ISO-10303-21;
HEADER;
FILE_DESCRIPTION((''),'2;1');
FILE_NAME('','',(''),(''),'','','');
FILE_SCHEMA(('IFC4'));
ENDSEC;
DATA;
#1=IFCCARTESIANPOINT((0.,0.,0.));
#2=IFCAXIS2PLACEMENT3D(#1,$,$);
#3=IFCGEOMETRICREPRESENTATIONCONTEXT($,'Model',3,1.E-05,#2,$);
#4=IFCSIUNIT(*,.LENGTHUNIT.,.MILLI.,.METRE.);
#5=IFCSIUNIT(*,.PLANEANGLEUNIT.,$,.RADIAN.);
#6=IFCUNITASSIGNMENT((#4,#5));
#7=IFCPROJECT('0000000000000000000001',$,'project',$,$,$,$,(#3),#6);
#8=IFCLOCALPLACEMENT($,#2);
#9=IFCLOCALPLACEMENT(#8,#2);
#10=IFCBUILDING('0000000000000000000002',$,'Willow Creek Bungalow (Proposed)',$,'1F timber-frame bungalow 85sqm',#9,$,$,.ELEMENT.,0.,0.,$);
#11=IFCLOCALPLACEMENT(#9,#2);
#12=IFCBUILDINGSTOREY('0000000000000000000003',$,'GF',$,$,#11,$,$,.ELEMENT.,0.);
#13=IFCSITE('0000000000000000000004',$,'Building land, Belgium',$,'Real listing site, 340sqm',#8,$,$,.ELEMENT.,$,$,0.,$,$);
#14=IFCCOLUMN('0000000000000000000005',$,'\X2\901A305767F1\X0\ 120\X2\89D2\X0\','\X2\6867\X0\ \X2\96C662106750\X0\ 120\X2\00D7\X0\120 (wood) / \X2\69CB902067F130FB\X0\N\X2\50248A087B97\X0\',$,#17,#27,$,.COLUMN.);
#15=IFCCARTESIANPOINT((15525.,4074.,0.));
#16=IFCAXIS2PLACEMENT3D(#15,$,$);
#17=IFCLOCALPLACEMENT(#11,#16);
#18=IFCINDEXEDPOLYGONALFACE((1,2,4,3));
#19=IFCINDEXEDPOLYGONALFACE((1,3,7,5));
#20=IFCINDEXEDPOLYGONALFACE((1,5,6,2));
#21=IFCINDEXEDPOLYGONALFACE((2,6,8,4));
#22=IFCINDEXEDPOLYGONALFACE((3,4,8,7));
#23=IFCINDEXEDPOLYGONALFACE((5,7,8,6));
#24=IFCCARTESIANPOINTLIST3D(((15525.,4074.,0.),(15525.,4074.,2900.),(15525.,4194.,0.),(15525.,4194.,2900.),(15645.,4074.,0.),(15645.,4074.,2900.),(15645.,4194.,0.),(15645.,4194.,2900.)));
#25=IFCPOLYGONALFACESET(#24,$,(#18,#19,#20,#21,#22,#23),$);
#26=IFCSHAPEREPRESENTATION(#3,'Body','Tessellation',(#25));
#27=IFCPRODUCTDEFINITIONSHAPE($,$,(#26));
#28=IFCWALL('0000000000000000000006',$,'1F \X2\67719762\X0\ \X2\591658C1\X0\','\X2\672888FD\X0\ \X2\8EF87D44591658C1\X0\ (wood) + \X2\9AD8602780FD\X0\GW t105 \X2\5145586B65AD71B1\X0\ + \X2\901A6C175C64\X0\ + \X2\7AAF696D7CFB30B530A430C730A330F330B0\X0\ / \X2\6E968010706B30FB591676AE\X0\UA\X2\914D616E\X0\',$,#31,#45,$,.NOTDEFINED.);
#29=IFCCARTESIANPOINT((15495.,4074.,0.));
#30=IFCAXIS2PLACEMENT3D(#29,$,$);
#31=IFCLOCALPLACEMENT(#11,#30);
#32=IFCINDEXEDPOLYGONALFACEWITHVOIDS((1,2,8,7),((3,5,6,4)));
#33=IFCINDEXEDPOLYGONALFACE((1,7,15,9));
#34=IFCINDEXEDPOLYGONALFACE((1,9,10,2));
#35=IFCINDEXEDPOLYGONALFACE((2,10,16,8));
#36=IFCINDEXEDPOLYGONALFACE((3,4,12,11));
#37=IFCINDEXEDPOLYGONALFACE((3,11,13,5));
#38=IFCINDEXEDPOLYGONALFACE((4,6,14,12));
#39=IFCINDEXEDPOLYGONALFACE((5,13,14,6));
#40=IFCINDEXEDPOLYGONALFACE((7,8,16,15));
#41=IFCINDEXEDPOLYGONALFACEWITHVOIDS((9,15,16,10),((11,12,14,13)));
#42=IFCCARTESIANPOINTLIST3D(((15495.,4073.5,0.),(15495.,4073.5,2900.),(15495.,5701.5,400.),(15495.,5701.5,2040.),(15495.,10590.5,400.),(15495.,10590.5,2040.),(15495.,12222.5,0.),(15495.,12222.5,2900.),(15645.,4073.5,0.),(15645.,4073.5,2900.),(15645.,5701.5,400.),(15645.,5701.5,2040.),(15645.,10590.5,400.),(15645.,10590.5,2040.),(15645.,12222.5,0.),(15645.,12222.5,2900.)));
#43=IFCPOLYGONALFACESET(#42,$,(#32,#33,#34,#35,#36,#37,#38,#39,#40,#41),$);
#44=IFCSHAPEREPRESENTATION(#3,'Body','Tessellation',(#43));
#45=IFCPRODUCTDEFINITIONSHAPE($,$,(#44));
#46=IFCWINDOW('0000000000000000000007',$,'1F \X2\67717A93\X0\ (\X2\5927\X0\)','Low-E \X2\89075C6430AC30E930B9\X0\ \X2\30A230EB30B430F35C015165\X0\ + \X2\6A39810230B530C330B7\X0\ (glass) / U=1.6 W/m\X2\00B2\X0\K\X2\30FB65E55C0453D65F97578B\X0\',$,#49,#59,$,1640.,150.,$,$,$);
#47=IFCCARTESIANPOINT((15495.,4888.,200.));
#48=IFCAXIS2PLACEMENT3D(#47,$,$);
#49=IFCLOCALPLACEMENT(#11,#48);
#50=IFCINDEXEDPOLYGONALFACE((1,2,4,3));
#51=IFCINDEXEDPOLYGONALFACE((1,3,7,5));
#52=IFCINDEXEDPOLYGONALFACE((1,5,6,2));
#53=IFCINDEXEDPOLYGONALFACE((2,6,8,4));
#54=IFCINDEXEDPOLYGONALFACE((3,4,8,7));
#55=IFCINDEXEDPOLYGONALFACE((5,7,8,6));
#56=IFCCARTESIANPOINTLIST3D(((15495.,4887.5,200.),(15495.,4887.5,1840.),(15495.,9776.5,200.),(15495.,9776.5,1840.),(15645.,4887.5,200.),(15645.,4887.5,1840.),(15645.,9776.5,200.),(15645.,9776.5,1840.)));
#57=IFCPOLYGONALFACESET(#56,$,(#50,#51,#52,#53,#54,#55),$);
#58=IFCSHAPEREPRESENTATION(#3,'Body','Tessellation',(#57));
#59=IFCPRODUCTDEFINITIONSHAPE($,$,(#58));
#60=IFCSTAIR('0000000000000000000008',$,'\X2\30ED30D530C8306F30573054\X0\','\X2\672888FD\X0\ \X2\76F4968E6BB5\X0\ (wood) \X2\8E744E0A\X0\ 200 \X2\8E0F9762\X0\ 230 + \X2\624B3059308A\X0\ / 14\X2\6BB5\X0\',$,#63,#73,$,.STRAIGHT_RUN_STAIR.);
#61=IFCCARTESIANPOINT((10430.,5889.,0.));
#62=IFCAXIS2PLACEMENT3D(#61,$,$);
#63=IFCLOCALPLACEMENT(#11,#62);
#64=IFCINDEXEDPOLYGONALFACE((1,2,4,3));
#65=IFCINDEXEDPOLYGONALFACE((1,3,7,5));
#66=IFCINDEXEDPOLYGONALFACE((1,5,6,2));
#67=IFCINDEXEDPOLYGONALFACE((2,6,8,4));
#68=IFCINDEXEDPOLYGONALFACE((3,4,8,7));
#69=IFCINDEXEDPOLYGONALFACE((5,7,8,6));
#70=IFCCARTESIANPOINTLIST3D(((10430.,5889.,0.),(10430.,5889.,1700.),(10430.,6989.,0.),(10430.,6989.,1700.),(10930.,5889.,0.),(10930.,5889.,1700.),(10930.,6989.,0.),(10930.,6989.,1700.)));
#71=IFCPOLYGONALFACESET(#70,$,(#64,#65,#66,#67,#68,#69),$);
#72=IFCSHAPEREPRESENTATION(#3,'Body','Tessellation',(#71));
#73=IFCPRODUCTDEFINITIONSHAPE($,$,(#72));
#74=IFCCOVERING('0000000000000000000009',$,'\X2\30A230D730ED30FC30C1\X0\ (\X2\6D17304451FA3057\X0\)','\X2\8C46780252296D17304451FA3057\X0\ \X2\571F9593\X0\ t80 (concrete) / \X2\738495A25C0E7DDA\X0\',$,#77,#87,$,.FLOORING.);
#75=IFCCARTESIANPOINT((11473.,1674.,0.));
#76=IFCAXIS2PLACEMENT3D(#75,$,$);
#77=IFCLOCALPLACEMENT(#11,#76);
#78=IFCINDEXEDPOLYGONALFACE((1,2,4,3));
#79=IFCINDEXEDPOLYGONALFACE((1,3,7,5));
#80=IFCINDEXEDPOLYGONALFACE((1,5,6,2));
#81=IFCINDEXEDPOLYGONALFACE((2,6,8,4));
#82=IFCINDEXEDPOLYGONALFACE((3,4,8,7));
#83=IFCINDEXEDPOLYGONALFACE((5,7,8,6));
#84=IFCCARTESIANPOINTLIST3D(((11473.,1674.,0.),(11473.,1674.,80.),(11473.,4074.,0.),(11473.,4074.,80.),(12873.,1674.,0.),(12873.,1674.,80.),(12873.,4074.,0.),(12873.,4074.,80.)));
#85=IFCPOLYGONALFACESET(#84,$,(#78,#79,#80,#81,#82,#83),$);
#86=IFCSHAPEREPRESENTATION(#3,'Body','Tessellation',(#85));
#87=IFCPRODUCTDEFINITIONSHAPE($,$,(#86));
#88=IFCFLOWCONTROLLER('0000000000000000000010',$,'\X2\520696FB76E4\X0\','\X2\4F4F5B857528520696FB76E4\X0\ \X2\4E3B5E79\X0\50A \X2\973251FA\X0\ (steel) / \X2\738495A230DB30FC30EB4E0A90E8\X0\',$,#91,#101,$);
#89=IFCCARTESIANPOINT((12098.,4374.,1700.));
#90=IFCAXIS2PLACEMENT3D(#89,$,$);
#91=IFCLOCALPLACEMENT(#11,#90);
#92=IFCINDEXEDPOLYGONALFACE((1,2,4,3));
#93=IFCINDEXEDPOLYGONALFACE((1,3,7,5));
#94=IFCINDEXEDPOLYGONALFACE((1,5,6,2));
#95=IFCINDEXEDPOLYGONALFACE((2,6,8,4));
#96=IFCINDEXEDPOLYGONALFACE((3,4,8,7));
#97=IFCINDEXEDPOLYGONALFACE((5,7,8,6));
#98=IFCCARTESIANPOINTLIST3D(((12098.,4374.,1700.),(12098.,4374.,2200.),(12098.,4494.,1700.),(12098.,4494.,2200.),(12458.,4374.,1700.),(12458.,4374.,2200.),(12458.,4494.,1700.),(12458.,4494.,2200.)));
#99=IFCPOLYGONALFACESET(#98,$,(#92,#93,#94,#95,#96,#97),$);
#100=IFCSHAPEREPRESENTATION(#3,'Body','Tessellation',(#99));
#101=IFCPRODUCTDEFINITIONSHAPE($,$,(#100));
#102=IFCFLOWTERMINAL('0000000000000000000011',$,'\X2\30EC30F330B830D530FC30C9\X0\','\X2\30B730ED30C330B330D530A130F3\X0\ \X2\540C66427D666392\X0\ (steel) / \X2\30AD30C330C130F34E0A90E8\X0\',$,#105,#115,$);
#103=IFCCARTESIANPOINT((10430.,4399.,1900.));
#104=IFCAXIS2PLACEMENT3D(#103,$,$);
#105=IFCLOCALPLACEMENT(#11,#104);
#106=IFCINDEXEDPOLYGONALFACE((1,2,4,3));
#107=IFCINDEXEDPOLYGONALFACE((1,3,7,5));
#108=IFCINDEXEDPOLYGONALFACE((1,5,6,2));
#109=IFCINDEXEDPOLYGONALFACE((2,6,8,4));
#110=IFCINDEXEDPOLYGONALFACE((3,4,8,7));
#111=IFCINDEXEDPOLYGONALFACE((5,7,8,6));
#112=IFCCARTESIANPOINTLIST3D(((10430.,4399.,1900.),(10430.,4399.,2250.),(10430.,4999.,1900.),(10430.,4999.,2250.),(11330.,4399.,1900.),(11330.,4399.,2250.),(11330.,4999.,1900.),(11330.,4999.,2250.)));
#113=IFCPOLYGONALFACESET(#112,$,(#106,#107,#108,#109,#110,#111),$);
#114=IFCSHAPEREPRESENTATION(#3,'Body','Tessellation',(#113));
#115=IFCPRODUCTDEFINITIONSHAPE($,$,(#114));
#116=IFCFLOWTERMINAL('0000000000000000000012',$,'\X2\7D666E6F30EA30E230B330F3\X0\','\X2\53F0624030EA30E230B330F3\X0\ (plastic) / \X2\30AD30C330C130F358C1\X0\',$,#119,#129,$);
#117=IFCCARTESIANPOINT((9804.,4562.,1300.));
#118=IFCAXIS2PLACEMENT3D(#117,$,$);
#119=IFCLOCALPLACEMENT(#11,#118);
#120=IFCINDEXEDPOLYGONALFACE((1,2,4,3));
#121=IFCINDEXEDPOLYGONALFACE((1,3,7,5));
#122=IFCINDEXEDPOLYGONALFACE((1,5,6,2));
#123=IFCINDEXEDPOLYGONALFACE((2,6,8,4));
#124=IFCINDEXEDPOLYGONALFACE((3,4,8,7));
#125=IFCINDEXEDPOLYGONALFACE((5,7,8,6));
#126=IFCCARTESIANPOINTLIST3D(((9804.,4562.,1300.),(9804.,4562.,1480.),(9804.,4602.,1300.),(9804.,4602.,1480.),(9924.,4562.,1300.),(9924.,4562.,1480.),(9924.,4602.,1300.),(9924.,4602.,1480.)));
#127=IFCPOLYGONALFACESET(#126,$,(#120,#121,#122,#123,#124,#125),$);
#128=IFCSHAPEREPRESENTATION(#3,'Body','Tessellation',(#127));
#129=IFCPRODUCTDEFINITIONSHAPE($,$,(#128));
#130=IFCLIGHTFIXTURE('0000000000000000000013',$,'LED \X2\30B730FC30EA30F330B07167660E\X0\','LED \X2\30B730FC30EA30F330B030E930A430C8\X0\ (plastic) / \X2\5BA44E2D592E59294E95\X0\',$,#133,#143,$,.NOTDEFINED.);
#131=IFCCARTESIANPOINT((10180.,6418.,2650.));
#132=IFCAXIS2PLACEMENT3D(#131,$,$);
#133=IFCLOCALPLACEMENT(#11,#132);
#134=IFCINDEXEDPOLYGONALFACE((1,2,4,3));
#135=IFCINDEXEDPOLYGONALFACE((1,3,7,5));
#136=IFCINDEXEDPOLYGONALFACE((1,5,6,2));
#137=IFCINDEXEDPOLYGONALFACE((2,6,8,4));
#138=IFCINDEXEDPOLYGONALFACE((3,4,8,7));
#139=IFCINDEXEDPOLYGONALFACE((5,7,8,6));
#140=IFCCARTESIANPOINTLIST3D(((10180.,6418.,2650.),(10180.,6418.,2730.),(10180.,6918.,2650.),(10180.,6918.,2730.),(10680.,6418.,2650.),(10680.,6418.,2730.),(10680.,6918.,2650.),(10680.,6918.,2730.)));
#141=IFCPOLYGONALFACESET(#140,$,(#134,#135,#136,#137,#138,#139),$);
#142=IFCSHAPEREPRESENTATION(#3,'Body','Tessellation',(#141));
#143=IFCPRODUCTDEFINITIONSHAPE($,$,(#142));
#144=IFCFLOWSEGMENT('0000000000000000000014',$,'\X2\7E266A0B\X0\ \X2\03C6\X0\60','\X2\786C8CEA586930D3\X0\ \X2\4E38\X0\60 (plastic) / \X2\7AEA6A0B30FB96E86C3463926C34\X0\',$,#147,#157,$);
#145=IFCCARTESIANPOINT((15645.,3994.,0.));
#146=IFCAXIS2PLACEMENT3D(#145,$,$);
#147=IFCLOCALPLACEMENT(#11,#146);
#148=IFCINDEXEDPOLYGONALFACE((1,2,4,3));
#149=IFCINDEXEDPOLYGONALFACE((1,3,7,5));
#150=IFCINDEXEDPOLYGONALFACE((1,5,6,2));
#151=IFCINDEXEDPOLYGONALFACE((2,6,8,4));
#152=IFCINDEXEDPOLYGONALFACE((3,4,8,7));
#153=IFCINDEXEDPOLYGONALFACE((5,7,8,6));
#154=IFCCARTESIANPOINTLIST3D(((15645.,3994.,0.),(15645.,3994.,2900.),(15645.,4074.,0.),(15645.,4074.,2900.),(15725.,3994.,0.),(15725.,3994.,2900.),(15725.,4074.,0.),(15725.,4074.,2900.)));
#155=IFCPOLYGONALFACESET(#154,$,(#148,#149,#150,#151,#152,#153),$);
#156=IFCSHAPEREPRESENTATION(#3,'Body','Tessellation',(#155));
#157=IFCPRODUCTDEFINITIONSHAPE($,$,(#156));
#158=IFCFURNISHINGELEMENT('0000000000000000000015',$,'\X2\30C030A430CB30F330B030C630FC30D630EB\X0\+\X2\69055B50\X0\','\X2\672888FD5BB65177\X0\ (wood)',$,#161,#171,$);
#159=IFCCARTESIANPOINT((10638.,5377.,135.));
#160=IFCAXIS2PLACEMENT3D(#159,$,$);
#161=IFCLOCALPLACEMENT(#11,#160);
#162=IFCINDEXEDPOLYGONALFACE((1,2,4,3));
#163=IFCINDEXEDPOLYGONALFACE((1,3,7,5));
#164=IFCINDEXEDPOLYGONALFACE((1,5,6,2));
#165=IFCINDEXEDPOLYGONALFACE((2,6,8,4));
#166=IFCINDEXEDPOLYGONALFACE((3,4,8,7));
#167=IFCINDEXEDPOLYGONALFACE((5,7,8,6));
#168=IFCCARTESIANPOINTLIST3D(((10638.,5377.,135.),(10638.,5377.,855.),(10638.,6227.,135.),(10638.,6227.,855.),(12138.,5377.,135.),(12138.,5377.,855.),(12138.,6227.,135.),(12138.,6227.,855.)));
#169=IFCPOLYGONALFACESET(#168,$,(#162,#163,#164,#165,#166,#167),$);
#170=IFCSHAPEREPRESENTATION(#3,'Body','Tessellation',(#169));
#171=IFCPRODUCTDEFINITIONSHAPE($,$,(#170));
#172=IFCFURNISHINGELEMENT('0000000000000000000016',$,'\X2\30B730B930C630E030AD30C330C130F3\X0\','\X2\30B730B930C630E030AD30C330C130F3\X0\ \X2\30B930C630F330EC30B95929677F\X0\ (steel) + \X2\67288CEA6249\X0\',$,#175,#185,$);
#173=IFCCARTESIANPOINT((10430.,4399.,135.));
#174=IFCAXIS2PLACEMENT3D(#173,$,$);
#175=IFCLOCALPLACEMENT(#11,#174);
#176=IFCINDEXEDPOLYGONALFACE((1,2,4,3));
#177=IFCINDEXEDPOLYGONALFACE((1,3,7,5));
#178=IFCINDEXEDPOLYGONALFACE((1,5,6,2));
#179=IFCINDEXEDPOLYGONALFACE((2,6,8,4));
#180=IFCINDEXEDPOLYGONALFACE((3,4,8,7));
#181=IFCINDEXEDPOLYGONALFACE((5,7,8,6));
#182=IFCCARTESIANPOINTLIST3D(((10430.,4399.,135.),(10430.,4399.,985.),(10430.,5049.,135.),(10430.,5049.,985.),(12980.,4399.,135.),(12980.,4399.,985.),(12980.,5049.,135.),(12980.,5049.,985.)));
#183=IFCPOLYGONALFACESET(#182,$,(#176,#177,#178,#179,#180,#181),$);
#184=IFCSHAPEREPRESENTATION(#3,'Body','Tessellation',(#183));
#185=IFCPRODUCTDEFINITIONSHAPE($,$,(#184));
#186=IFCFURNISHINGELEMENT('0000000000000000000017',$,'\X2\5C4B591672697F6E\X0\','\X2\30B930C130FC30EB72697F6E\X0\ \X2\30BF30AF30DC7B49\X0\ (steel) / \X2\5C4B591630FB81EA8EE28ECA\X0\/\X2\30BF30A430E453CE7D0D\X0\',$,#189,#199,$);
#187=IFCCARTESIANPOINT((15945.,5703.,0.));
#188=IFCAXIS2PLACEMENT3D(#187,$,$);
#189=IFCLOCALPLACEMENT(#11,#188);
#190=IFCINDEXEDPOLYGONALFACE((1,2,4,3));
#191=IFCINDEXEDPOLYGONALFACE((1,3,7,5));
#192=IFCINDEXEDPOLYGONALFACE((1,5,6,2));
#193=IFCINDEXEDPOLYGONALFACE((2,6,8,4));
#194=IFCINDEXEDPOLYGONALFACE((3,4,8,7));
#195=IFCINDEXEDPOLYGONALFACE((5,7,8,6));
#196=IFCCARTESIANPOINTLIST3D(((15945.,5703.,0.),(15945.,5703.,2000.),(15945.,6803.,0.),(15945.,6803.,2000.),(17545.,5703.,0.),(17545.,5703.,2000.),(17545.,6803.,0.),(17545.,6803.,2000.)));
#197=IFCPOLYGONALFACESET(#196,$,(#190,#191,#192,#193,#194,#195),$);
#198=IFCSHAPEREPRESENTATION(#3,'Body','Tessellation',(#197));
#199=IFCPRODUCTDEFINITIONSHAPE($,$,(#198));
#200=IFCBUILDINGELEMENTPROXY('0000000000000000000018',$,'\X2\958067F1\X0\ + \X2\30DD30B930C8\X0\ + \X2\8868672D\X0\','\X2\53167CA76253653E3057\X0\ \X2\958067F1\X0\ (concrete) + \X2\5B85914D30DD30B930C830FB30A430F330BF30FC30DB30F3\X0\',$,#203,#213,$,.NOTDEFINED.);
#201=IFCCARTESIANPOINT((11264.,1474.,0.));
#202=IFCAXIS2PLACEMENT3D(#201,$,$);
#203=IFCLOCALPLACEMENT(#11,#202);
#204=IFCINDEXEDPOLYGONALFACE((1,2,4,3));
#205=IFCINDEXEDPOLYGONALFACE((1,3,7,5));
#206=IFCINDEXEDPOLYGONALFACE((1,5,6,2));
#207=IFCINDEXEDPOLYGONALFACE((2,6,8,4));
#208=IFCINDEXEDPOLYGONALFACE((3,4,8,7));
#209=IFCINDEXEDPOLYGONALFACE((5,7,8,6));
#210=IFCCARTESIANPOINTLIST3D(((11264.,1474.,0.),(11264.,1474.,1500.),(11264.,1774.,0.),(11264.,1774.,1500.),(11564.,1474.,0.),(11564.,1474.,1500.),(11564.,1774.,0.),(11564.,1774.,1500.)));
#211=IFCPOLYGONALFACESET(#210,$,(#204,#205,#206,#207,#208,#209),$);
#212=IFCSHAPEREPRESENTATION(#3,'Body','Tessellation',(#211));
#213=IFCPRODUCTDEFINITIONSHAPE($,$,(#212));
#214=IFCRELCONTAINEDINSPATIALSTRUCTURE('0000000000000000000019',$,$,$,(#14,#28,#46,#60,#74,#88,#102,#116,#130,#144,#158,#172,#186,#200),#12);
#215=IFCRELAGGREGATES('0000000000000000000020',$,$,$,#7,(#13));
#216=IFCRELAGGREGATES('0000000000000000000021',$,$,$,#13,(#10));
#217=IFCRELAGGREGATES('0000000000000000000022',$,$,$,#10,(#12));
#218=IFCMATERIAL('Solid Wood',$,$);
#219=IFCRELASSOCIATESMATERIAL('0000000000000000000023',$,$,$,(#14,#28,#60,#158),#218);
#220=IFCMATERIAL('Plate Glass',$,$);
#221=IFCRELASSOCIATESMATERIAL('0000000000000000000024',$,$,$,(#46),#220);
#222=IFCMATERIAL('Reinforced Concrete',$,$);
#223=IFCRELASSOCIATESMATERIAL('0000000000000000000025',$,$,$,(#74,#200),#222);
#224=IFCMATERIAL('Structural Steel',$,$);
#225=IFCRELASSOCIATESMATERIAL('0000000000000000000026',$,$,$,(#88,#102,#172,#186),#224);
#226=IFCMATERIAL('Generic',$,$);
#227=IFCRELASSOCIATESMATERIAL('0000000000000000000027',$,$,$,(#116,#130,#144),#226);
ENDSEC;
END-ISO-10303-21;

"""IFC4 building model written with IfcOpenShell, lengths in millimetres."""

from ifc_helpers import new_model, si_unit, frame, frame_2d, origin, place, context, project, spatial, rectangle, extrude, material, element, fill, save


model = new_model("IFC4")

# Units and contexts
model_context = context("Model", 3, precision=1e-05, world=origin())
ifc_project = project(units=[si_unit("LENGTHUNIT", "METRE", prefix="MILLI"), si_unit("PLANEANGLEUNIT", "RADIAN")], contexts=[model_context])

# Site, building, storey
site_placement = place(None, origin())
site = spatial("IfcSite", under=ifc_project, at=site_placement, Name="Building land, Belgium", ObjectType="Real listing site, 340sqm", CompositionType="ELEMENT", RefElevation=0.0)
building_placement = place(site_placement, origin())
building = spatial("IfcBuilding", under=site, at=building_placement, Name="Willow Creek Bungalow (Proposed)", ObjectType="1F timber-frame bungalow 85sqm", CompositionType="ELEMENT", ElevationOfRefHeight=0.0, ElevationOfTerrain=0.0)
storey_placement = place(building_placement, origin())
storey = spatial("IfcBuildingStorey", under=building, at=storey_placement, Name="GF", CompositionType="ELEMENT", Elevation=0.0)

# Column
ifc_material_1 = material(Name="Solid Wood")
column_1_placement = place(storey_placement, frame((15525.0, 4074.0, 0.0)))
element("IfcColumn", 1, at=column_1_placement, inside=storey, material=ifc_material_1, Name="通し柱 120角", Description="桧 集成材 120×120 (wood) / 構造柱・N値計算", PredefinedType="COLUMN", context=model_context, shape_type="SweptSolid", body=[
    extrude(rectangle(XDim=120.0, YDim=120.0, at=frame_2d((60.0, 60.0))), frame((15525.0, 4074.0, 0.0)), (0.0, 0.0, 1.0), 2900.0),
])

# Wall, opening, window
wall_1_placement = place(storey_placement, frame((15495.0, 4074.0, 0.0)))
wall_1 = element("IfcWall", 2, at=wall_1_placement, inside=storey, material=ifc_material_1, Name="1F 東面 外壁", Description="木製 軸組外壁 (wood) + 高性能GW t105 充填断熱 + 通気層 + 窯業系サイディング / 準耐火・外皮UA配慮", PredefinedType="NOTDEFINED", context=model_context, shape_type="SweptSolid", body=[
    extrude(rectangle(XDim=150.0, YDim=8149.0, at=frame_2d((75.0, 4074.0))), frame((15495.0, 4074.0, 0.0)), (0.0, 0.0, 1.0), 2900.0),
])
opening_placement = place(storey_placement, frame((15495.0, 4888.0, 200.0)))
opening = element("IfcOpeningElement", 3, at=opening_placement, cuts=wall_1, PredefinedType="NOTDEFINED", context=model_context, shape_type="SweptSolid", body=[
    extrude(rectangle(XDim=150.0, YDim=4889.0, at=frame_2d((75.0, 2444.0))), frame((15495.0, 4888.0, 200.0)), (0.0, 0.0, 1.0), 1640.0),
])
ifc_material_2 = material(Name="Plate Glass")
window_placement = place(storey_placement, frame((15495.0, 4888.0, 200.0)))
window = element("IfcWindow", 4, at=window_placement, inside=storey, material=ifc_material_2, Name="1F 東窓 (大)", Description="Low-E 複層ガラス アルゴン封入 + 樹脂サッシ (glass) / U=1.6 W/m²K・日射取得型", OverallHeight=1640.0, OverallWidth=150.0, context=model_context, shape_type="SweptSolid", body=[
    extrude(rectangle(XDim=150.0, YDim=4889.0, at=frame_2d((75.0, 2444.0))), frame((15495.0, 4888.0, 200.0)), (0.0, 0.0, 1.0), 1640.0),
])
fill(opening, window)

# Stair
stair_placement = place(storey_placement, frame((10430.0, 5889.0, 0.0)))
element("IfcStair", 5, at=stair_placement, inside=storey, material=ifc_material_1, Name="ロフトはしご", Description="木製 直階段 (wood) 蹴上 200 踏面 230 + 手すり / 14段", PredefinedType="STRAIGHT_RUN_STAIR", context=model_context, shape_type="SweptSolid", body=[
    extrude(rectangle(XDim=500.0, YDim=1100.0, at=frame_2d((250.0, 550.0))), frame((10430.0, 5889.0, 0.0)), (0.0, 0.0, 1.0), 1700.0),
])

# Covering
ifc_material_3 = material(Name="Reinforced Concrete")
covering_placement = place(storey_placement, frame((11473.0, 1674.0, 0.0)))
element("IfcCovering", 6, at=covering_placement, inside=storey, material=ifc_material_3, Name="アプローチ (洗い出し)", Description="豆砂利洗い出し 土間 t80 (concrete) / 玄関導線", PredefinedType="FLOORING", context=model_context, shape_type="SweptSolid", body=[
    extrude(rectangle(XDim=1400.0, YDim=2400.0, at=frame_2d((700.0, 1200.0))), frame((11473.0, 1674.0, 0.0)), (0.0, 0.0, 1.0), 80.0),
])

# Flow controller
ifc_material_4 = material(Name="Structural Steel")
flow_controller_placement = place(storey_placement, frame((12098.0, 4374.0, 1700.0)))
element("IfcFlowController", 7, at=flow_controller_placement, inside=storey, material=ifc_material_4, Name="分電盤", Description="住宅用分電盤 主幹50A 露出 (steel) / 玄関ホール上部", context=model_context, shape_type="SweptSolid", body=[
    extrude(rectangle(XDim=360.0, YDim=120.0, at=frame_2d((180.0, 60.0))), frame((12098.0, 4374.0, 1700.0)), (0.0, 0.0, 1.0), 500.0),
])

# Flow terminals
flow_terminal_1_placement = place(storey_placement, frame((10430.0, 4399.0, 1900.0)))
element("IfcFlowTerminal", 8, at=flow_terminal_1_placement, inside=storey, material=ifc_material_4, Name="レンジフード", Description="シロッコファン 同時給排 (steel) / キッチン上部", context=model_context, shape_type="SweptSolid", body=[
    extrude(rectangle(XDim=900.0, YDim=600.0, at=frame_2d((450.0, 300.0))), frame((10430.0, 4399.0, 1900.0)), (0.0, 0.0, 1.0), 350.0),
])
ifc_material_5 = material(Name="Generic")
flow_terminal_2_placement = place(storey_placement, frame((9804.0, 4562.0, 1300.0)))
element("IfcFlowTerminal", 9, at=flow_terminal_2_placement, inside=storey, material=ifc_material_5, Name="給湯リモコン", Description="台所リモコン (plastic) / キッチン壁", context=model_context, shape_type="SweptSolid", body=[
    extrude(rectangle(XDim=120.0, YDim=40.0, at=frame_2d((60.0, 20.0))), frame((9804.0, 4562.0, 1300.0)), (0.0, 0.0, 1.0), 180.0),
])

# Light fixture
light_fixture_placement = place(storey_placement, frame((10180.0, 6418.0, 2650.0)))
element("IfcLightFixture", 10, at=light_fixture_placement, inside=storey, material=ifc_material_5, Name="LED シーリング照明", Description="LED シーリングライト (plastic) / 室中央天井", PredefinedType="NOTDEFINED", context=model_context, shape_type="SweptSolid", body=[
    extrude(rectangle(XDim=500.0, YDim=500.0, at=frame_2d((250.0, 250.0))), frame((10180.0, 6418.0, 2650.0)), (0.0, 0.0, 1.0), 80.0),
])

# Flow segment
flow_segment_placement = place(storey_placement, frame((15645.0, 3994.0, 0.0)))
element("IfcFlowSegment", 11, at=flow_segment_placement, inside=storey, material=ifc_material_5, Name="縦樋 φ60", Description="硬質塩ビ 丸60 (plastic) / 竪樋・雨水排水", context=model_context, shape_type="SweptSolid", body=[
    extrude(rectangle(XDim=80.0, YDim=80.0, at=frame_2d((40.0, 40.0))), frame((15645.0, 3994.0, 0.0)), (0.0, 0.0, 1.0), 2900.0),
])

# Furnishing elements
furnishing_1_placement = place(storey_placement, frame((10638.0, 5377.0, 135.0)))
element("IfcFurnishingElement", 12, at=furnishing_1_placement, inside=storey, material=ifc_material_1, Name="ダイニングテーブル+椅子", Description="木製家具 (wood)", context=model_context, shape_type="SweptSolid", body=[
    extrude(rectangle(XDim=1500.0, YDim=850.0, at=frame_2d((750.0, 425.0))), frame((10638.0, 5377.0, 135.0)), (0.0, 0.0, 1.0), 720.0),
])
furnishing_2_placement = place(storey_placement, frame((10430.0, 4399.0, 135.0)))
element("IfcFurnishingElement", 13, at=furnishing_2_placement, inside=storey, material=ifc_material_4, Name="システムキッチン", Description="システムキッチン ステンレス天板 (steel) + 木質扉", context=model_context, shape_type="SweptSolid", body=[
    extrude(rectangle(XDim=2550.0, YDim=650.0, at=frame_2d((1275.0, 325.0))), frame((10430.0, 4399.0, 135.0)), (0.0, 0.0, 1.0), 850.0),
])
furnishing_3_placement = place(storey_placement, frame((15945.0, 5703.0, 0.0)))
element("IfcFurnishingElement", 14, at=furnishing_3_placement, inside=storey, material=ifc_material_4, Name="屋外物置", Description="スチール物置 タクボ等 (steel) / 屋外・自転車/タイヤ収納", context=model_context, shape_type="SweptSolid", body=[
    extrude(rectangle(XDim=1600.0, YDim=1100.0, at=frame_2d((800.0, 550.0))), frame((15945.0, 5703.0, 0.0)), (0.0, 0.0, 1.0), 2000.0),
])

# Building element proxy
proxy_placement = place(storey_placement, frame((11264.0, 1474.0, 0.0)))
element("IfcBuildingElementProxy", 15, at=proxy_placement, inside=storey, material=ifc_material_3, Name="門柱 + ポスト + 表札", Description="化粧打放し 門柱 (concrete) + 宅配ポスト・インターホン", PredefinedType="NOTDEFINED", context=model_context, shape_type="SweptSolid", body=[
    extrude(rectangle(XDim=300.0, YDim=300.0, at=frame_2d((150.0, 150.0))), frame((11264.0, 1474.0, 0.0)), (0.0, 0.0, 1.0), 1500.0),
])

save(model, "model.ifc")
